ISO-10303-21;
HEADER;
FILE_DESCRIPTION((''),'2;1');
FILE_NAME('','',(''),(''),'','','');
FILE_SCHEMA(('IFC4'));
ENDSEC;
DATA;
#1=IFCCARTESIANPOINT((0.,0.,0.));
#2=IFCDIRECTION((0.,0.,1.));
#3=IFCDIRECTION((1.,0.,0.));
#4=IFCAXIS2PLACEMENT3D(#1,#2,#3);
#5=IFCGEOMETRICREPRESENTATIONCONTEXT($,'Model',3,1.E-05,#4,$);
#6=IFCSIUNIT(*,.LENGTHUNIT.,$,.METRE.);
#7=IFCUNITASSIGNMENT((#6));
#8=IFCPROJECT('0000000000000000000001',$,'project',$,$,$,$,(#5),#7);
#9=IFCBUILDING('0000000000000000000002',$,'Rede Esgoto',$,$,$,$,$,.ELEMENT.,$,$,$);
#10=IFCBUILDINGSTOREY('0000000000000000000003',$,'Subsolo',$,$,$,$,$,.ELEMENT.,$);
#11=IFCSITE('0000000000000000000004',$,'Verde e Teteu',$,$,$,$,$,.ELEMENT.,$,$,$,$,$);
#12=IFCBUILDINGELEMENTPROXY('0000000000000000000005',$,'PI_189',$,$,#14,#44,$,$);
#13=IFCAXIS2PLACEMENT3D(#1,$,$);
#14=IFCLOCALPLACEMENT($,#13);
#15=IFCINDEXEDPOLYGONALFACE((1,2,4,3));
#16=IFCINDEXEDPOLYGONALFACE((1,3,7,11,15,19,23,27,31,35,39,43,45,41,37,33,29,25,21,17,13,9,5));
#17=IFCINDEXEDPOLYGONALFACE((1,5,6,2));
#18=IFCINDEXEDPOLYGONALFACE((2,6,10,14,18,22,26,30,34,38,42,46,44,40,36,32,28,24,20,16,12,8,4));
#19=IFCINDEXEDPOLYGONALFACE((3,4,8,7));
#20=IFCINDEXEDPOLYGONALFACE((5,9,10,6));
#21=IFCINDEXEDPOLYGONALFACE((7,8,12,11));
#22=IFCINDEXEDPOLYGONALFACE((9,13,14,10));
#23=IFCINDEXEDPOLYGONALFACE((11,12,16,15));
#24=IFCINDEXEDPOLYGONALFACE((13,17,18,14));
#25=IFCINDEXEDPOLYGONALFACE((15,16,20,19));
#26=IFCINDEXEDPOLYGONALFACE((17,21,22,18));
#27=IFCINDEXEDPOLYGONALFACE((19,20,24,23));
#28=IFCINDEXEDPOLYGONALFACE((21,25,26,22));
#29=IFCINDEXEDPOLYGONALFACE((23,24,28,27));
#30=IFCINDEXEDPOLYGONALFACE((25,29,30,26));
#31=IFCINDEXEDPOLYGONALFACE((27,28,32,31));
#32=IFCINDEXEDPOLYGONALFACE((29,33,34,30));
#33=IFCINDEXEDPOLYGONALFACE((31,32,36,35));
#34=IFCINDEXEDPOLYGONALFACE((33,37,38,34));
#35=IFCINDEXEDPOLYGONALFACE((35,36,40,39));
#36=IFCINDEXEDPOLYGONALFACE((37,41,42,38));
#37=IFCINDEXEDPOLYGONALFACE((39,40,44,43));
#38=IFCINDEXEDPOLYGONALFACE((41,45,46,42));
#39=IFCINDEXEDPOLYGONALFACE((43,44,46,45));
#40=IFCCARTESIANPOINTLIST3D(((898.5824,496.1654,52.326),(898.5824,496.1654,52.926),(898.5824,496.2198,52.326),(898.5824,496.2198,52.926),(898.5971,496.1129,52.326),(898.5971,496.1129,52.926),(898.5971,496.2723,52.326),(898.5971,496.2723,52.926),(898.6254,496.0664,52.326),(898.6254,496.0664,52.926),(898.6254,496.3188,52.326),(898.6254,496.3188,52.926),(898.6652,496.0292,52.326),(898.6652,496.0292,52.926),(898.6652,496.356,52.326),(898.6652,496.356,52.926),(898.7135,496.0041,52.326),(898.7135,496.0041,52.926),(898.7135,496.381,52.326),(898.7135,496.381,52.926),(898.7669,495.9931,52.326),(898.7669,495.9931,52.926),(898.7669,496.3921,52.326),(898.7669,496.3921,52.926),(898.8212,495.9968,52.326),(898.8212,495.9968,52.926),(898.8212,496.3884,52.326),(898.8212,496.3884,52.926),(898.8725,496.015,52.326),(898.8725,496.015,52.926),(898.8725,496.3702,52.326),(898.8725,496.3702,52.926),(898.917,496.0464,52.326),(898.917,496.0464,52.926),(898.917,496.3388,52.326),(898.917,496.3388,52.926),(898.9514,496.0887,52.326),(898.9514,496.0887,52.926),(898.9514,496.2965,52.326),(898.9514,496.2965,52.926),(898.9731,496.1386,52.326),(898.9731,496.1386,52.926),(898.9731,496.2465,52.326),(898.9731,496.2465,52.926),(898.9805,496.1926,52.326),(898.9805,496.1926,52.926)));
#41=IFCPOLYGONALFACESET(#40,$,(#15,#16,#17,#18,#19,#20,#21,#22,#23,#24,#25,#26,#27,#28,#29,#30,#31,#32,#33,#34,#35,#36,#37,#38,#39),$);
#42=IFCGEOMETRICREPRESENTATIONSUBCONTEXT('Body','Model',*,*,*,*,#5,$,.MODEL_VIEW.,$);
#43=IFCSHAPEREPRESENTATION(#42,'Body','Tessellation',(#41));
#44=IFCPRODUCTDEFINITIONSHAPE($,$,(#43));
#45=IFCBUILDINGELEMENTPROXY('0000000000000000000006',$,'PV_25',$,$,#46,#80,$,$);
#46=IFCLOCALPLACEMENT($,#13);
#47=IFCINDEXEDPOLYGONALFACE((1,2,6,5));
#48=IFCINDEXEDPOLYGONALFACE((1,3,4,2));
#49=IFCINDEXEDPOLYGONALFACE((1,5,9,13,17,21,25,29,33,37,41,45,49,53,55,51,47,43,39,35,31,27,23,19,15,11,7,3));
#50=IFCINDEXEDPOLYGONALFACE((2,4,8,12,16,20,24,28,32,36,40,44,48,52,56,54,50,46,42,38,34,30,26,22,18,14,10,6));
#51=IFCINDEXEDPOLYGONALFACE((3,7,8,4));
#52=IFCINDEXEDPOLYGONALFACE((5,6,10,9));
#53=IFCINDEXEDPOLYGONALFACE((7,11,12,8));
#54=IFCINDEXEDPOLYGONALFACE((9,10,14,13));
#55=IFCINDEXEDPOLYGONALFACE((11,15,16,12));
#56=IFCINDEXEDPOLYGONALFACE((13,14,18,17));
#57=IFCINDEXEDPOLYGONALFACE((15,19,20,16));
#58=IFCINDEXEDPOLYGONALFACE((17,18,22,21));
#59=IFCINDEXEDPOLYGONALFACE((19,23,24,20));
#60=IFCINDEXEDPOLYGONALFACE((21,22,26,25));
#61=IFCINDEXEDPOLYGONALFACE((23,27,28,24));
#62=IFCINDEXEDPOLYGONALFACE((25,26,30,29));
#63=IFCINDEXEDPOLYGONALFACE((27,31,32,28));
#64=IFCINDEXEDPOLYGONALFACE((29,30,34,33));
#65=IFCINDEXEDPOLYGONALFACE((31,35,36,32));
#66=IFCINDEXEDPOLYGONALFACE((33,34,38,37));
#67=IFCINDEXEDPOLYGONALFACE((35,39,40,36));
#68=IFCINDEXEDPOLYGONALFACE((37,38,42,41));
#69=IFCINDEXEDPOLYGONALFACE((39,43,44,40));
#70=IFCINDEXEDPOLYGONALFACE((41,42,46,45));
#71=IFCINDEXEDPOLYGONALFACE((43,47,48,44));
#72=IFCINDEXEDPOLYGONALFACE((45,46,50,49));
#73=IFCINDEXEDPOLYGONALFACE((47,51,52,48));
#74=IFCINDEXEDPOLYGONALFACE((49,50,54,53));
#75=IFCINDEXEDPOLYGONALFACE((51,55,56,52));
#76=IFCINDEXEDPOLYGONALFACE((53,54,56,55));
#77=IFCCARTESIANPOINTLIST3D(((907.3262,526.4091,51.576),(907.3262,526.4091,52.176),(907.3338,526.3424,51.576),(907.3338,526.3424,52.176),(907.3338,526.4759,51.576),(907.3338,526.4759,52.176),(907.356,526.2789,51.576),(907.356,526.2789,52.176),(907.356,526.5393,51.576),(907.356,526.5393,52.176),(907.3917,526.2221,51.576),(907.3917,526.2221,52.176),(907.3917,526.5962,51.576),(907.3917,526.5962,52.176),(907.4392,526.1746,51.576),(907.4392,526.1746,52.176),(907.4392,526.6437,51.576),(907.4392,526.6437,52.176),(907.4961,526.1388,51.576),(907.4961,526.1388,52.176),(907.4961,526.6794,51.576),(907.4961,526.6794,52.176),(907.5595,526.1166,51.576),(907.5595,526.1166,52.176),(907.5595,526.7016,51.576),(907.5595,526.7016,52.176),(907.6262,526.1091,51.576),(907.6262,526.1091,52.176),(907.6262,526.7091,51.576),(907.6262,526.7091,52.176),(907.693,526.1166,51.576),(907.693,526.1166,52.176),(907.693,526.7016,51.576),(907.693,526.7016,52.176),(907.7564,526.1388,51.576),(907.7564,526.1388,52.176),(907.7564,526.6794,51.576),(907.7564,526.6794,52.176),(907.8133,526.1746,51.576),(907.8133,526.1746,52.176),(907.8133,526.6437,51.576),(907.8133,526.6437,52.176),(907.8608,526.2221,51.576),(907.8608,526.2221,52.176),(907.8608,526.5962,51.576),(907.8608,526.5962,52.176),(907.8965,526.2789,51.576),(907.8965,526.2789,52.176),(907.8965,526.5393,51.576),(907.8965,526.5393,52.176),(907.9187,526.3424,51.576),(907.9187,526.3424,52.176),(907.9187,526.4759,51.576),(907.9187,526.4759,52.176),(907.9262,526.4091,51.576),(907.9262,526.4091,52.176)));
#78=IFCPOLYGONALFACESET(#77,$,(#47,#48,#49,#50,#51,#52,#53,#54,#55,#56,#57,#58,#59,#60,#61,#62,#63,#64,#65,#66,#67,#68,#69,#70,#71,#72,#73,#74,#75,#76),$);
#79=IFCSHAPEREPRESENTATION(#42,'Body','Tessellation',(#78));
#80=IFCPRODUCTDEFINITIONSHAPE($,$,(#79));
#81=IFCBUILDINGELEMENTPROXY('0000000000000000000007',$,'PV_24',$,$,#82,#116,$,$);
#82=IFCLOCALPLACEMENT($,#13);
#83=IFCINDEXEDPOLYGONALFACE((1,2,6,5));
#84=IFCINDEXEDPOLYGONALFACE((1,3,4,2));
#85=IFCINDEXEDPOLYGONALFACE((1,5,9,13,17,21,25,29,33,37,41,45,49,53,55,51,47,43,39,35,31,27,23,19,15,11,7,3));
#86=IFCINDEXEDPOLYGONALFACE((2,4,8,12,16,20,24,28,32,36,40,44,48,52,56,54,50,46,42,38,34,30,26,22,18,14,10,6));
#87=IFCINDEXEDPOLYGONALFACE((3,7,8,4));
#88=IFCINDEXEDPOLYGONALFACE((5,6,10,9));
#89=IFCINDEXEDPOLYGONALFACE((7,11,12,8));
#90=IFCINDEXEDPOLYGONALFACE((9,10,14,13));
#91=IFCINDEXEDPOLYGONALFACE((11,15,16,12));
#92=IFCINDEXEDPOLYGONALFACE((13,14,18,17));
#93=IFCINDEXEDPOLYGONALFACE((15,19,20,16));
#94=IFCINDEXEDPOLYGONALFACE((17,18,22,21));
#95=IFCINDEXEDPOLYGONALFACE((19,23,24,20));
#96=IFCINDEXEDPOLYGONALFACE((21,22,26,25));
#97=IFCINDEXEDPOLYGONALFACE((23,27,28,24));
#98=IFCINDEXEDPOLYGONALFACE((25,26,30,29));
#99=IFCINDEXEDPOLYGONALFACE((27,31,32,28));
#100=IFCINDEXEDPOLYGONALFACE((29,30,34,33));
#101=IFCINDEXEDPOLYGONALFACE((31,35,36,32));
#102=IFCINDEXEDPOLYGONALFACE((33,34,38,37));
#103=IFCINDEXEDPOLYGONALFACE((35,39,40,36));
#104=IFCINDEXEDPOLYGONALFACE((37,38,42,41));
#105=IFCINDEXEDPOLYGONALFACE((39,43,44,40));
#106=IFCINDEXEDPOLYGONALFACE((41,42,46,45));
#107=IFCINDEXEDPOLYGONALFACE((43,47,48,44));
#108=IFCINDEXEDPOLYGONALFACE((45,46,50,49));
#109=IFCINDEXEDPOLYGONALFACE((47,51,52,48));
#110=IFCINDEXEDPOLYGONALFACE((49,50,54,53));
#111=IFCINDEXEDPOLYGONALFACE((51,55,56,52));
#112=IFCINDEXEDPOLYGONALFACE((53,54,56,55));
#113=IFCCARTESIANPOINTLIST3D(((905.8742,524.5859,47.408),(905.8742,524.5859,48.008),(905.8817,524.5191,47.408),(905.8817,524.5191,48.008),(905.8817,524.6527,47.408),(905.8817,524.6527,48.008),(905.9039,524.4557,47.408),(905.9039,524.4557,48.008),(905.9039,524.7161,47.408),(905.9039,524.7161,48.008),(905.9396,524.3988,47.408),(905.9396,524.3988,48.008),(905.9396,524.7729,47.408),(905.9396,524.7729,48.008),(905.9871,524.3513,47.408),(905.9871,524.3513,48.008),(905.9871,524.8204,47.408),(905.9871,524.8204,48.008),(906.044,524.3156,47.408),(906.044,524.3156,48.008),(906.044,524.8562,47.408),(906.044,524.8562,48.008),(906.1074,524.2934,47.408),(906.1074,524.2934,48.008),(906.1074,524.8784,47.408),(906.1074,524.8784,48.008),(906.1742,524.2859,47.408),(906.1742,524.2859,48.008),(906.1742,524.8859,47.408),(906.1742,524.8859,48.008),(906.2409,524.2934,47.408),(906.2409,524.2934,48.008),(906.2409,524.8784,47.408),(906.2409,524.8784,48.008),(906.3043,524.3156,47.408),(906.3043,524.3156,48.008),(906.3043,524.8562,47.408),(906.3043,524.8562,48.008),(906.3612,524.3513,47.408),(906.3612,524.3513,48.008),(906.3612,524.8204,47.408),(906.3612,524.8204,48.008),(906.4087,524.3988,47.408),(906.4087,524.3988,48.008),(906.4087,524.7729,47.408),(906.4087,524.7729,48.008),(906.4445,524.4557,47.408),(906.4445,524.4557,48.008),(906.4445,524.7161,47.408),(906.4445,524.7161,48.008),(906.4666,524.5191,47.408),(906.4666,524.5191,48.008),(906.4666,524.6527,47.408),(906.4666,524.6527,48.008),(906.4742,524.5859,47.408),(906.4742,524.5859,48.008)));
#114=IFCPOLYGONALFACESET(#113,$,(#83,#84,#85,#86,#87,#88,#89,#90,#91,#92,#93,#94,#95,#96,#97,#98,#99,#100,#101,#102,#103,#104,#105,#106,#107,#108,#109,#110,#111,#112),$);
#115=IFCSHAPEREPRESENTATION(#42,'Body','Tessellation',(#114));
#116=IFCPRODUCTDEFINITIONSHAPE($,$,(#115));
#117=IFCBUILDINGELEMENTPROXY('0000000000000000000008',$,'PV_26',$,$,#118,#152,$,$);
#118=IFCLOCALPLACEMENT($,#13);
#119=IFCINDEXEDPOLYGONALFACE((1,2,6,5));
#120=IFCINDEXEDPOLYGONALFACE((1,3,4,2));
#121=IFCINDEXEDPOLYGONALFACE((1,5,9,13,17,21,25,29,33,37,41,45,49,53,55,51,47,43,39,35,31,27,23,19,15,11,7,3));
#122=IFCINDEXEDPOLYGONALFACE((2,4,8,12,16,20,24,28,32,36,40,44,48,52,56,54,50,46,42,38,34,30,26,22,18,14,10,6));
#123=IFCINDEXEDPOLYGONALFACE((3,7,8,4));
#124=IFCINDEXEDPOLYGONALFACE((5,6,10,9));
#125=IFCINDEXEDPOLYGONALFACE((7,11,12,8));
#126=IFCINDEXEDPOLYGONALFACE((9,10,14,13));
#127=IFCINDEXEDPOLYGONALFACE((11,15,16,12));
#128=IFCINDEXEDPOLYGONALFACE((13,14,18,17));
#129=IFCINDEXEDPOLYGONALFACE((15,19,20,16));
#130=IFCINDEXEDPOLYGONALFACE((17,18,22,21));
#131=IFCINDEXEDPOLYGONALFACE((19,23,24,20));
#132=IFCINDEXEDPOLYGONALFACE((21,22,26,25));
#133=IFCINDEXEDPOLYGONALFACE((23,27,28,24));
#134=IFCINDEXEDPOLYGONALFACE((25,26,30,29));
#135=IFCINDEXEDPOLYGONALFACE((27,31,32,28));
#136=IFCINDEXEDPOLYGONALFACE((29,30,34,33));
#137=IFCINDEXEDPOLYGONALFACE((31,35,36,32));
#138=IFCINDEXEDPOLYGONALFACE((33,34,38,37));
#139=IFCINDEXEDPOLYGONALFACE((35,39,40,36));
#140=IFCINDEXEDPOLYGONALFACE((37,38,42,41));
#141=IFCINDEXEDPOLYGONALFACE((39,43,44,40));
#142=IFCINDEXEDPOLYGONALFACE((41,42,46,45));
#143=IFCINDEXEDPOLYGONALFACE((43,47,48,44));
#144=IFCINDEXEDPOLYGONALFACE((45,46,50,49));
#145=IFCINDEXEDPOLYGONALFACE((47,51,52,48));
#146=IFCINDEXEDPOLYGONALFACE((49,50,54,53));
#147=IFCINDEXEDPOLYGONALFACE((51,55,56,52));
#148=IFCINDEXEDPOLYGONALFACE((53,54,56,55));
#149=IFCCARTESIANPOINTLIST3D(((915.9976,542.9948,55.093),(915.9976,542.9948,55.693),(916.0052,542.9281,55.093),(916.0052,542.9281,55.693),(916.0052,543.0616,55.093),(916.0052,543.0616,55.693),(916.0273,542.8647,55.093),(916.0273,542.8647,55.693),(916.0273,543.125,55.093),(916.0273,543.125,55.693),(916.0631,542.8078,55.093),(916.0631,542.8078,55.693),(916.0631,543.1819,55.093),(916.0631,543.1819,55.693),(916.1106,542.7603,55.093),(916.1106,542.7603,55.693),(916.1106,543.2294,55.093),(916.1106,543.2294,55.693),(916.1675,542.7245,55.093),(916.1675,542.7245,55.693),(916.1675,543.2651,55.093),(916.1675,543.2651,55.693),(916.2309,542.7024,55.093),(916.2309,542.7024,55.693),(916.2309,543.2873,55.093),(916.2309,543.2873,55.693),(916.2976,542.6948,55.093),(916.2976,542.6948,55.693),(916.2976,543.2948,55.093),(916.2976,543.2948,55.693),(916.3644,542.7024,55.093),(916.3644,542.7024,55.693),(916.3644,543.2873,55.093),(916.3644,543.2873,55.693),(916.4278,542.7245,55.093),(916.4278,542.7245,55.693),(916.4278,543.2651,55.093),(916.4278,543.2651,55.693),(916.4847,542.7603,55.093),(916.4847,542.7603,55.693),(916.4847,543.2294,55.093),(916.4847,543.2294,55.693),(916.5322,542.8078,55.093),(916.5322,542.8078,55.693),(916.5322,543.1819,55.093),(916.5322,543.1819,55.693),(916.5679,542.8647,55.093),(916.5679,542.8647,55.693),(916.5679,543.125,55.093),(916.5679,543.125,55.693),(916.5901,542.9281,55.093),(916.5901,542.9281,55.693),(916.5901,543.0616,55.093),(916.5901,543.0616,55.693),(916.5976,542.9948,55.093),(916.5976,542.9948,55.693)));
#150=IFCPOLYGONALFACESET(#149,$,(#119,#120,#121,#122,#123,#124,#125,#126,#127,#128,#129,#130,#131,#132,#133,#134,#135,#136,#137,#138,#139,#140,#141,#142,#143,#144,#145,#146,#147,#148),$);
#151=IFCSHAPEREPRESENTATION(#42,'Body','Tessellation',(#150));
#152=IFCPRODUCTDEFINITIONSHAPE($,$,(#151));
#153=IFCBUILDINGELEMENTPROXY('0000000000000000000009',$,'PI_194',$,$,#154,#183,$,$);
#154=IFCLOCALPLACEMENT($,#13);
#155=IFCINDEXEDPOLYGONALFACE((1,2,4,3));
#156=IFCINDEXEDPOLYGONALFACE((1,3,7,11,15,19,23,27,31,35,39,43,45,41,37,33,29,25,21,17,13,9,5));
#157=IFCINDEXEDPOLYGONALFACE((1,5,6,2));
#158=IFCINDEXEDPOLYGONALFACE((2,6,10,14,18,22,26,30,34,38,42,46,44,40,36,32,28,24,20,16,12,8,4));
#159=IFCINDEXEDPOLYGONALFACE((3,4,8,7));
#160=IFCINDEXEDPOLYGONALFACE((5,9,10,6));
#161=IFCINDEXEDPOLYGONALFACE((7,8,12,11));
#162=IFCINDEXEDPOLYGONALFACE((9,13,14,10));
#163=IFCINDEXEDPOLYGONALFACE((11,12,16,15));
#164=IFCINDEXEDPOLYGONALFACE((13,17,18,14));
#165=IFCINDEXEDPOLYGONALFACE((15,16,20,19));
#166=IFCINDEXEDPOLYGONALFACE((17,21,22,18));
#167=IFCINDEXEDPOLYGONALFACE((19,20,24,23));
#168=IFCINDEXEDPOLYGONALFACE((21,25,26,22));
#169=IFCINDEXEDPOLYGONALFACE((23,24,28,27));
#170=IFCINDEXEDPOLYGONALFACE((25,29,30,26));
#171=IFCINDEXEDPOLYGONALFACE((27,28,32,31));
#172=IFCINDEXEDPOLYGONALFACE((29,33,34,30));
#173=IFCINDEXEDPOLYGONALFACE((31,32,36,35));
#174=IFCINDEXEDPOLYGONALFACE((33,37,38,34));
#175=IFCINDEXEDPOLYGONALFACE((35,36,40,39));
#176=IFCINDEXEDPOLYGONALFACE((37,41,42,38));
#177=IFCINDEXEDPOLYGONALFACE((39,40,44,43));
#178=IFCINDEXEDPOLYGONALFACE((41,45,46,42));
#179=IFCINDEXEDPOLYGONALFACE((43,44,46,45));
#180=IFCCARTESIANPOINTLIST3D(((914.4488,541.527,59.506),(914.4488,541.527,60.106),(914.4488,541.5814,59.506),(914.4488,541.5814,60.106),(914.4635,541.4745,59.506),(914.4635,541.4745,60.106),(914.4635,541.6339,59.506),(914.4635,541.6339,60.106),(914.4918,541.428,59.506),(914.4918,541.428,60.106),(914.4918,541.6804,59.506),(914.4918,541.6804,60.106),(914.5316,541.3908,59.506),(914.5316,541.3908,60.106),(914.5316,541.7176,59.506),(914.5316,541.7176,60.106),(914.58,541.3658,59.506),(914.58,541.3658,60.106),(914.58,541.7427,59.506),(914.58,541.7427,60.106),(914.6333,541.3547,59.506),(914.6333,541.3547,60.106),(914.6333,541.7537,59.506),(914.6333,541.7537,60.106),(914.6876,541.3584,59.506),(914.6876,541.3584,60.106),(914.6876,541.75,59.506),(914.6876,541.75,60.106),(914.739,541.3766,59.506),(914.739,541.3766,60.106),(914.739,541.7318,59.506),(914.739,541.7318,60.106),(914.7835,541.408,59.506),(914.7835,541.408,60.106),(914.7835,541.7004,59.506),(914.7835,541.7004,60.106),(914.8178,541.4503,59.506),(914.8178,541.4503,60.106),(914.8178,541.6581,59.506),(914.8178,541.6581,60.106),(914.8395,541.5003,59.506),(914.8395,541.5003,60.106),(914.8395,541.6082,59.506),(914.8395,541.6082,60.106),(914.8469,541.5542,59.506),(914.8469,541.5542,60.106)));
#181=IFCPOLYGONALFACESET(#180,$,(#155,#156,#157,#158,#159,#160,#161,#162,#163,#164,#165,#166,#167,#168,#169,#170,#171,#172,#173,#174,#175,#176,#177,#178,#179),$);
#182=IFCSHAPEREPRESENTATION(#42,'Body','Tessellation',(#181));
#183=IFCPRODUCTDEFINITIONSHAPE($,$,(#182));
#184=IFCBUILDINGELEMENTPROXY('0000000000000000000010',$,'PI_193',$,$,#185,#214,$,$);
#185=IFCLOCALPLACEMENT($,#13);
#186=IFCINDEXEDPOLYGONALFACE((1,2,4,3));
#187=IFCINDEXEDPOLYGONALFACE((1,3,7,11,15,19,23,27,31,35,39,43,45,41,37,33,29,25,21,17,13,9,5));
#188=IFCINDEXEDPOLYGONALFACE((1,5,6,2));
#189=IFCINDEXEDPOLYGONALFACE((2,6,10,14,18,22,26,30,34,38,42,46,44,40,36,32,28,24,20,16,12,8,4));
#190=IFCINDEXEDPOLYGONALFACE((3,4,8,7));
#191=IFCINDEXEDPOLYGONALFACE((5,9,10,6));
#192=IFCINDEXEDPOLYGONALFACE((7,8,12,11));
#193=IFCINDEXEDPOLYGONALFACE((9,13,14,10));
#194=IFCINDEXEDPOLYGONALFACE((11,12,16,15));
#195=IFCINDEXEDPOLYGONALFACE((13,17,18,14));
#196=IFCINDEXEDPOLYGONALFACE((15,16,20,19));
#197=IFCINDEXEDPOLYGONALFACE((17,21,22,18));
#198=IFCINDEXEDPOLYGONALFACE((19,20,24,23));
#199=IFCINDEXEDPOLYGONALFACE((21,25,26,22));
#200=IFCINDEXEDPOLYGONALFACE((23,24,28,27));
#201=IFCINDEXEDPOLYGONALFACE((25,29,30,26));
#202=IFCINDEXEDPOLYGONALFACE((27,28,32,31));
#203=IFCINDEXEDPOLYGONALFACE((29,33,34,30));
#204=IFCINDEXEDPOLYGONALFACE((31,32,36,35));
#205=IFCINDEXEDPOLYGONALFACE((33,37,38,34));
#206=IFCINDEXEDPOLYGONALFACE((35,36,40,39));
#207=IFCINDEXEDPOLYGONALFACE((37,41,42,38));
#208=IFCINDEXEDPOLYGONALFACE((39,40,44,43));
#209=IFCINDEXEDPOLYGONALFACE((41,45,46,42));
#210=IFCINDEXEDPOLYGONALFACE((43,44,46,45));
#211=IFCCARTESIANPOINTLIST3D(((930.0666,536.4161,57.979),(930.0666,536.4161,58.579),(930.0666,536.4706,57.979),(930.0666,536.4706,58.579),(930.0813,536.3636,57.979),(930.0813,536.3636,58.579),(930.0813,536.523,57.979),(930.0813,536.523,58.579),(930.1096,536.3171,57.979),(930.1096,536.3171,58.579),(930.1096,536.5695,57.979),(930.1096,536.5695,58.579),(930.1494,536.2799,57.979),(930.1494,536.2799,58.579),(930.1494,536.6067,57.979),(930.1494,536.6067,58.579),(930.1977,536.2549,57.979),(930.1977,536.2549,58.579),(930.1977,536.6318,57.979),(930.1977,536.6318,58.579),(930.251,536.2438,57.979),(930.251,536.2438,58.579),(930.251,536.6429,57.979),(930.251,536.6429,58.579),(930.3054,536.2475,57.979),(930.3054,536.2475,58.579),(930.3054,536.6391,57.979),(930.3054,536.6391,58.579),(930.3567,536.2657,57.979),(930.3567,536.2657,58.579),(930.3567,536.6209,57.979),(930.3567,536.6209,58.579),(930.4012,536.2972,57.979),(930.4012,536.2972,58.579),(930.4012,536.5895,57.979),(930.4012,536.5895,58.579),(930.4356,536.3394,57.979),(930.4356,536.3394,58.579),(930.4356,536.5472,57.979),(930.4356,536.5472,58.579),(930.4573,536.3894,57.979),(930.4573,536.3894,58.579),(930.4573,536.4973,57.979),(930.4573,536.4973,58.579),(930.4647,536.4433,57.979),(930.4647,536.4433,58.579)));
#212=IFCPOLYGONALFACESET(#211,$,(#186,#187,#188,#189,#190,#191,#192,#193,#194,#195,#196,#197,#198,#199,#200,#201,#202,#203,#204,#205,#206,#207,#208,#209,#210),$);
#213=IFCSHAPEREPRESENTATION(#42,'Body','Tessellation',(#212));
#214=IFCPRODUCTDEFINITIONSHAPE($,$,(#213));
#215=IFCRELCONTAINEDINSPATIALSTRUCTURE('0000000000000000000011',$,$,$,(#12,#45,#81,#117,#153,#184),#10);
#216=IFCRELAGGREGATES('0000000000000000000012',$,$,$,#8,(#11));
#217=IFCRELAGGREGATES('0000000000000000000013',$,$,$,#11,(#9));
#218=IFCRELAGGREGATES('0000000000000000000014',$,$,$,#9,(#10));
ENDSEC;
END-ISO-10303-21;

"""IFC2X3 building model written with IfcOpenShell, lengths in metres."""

from ifc_helpers import new_model, si_unit, frame, origin_with_axes, origin_2d, place, context, subcontext, project, spatial, circle, extrude, element, save


model = new_model("IFC2X3")

# Units and contexts
model_context = context("Model", 3, precision=1e-05, world=origin_with_axes())
body_context = subcontext(model_context, "Body", "Model", "MODEL_VIEW")
ifc_project = project(units=[si_unit("LENGTHUNIT", "METRE")], contexts=[model_context])

# Site, building, storey
site = spatial("IfcSite", under=ifc_project, Name="Verde e Teteu", CompositionType="ELEMENT")
building = spatial("IfcBuilding", under=site, Name="Rede Esgoto", CompositionType="ELEMENT")
storey = spatial("IfcBuildingStorey", under=building, Name="Subsolo", CompositionType="ELEMENT")

# Building element proxies
proxy_1_placement = place(None, frame((898.7805, 496.1926, 52.326), z_axis=(0.0, 0.0, 1.0), x_axis=(1.0, 0.0, 0.0)))
element("IfcBuildingElementProxy", 1, at=proxy_1_placement, inside=storey, Name="PI_189", context=body_context, shape_type="SweptSolid", body=[
    extrude(circle(Radius=0.2, at=origin_2d()), origin_with_axes(), (0.0, 0.0, 1.0), 0.6),
])
for number, where, z_axis, x_axis, name in (
    (2, (907.6262, 526.4091, 51.576), (0.0, 0.0, 1.0), (1.0, 0.0, 0.0), "PV_25"),
    (3, (906.1742, 524.5859, 47.408), (0.0, 0.0, 1.0), (1.0, 0.0, 0.0), "PV_24"),
):
    element("IfcBuildingElementProxy", number, at=place(None, frame(where, z_axis=z_axis, x_axis=x_axis)), inside=storey, Name=name, context=body_context, shape_type="SweptSolid", body=[
        extrude(circle(Radius=0.3, at=origin_2d()), origin_with_axes(), (0.0, 0.0, 1.0), 0.6),
    ])
proxy_2_placement = place(None, frame((916.2976, 542.9948, 55.093), z_axis=(0.0, 0.0, 1.0), x_axis=(1.0, 0.0, 0.0)))
element("IfcBuildingElementProxy", 4, at=proxy_2_placement, inside=storey, Name="PV_26", context=body_context, shape_type="SweptSolid", body=[
    extrude(circle(Radius=0.3, at=origin_2d()), origin_with_axes(), (0.0, 0.0, 1.0), 0.6),
])
for number, where, z_axis, x_axis, name in (
    (5, (914.6469, 541.5542, 59.506), (0.0, 0.0, 1.0), (1.0, 0.0, 0.0), "PI_194"),
    (6, (930.2647, 536.4433, 57.979), (0.0, 0.0, 1.0), (1.0, 0.0, 0.0), "PI_193"),
):
    element("IfcBuildingElementProxy", number, at=place(None, frame(where, z_axis=z_axis, x_axis=x_axis)), inside=storey, Name=name, context=body_context, shape_type="SweptSolid", body=[
        extrude(circle(Radius=0.2, at=origin_2d()), origin_with_axes(), (0.0, 0.0, 1.0), 0.6),
    ])

save(model, "model.ifc")
